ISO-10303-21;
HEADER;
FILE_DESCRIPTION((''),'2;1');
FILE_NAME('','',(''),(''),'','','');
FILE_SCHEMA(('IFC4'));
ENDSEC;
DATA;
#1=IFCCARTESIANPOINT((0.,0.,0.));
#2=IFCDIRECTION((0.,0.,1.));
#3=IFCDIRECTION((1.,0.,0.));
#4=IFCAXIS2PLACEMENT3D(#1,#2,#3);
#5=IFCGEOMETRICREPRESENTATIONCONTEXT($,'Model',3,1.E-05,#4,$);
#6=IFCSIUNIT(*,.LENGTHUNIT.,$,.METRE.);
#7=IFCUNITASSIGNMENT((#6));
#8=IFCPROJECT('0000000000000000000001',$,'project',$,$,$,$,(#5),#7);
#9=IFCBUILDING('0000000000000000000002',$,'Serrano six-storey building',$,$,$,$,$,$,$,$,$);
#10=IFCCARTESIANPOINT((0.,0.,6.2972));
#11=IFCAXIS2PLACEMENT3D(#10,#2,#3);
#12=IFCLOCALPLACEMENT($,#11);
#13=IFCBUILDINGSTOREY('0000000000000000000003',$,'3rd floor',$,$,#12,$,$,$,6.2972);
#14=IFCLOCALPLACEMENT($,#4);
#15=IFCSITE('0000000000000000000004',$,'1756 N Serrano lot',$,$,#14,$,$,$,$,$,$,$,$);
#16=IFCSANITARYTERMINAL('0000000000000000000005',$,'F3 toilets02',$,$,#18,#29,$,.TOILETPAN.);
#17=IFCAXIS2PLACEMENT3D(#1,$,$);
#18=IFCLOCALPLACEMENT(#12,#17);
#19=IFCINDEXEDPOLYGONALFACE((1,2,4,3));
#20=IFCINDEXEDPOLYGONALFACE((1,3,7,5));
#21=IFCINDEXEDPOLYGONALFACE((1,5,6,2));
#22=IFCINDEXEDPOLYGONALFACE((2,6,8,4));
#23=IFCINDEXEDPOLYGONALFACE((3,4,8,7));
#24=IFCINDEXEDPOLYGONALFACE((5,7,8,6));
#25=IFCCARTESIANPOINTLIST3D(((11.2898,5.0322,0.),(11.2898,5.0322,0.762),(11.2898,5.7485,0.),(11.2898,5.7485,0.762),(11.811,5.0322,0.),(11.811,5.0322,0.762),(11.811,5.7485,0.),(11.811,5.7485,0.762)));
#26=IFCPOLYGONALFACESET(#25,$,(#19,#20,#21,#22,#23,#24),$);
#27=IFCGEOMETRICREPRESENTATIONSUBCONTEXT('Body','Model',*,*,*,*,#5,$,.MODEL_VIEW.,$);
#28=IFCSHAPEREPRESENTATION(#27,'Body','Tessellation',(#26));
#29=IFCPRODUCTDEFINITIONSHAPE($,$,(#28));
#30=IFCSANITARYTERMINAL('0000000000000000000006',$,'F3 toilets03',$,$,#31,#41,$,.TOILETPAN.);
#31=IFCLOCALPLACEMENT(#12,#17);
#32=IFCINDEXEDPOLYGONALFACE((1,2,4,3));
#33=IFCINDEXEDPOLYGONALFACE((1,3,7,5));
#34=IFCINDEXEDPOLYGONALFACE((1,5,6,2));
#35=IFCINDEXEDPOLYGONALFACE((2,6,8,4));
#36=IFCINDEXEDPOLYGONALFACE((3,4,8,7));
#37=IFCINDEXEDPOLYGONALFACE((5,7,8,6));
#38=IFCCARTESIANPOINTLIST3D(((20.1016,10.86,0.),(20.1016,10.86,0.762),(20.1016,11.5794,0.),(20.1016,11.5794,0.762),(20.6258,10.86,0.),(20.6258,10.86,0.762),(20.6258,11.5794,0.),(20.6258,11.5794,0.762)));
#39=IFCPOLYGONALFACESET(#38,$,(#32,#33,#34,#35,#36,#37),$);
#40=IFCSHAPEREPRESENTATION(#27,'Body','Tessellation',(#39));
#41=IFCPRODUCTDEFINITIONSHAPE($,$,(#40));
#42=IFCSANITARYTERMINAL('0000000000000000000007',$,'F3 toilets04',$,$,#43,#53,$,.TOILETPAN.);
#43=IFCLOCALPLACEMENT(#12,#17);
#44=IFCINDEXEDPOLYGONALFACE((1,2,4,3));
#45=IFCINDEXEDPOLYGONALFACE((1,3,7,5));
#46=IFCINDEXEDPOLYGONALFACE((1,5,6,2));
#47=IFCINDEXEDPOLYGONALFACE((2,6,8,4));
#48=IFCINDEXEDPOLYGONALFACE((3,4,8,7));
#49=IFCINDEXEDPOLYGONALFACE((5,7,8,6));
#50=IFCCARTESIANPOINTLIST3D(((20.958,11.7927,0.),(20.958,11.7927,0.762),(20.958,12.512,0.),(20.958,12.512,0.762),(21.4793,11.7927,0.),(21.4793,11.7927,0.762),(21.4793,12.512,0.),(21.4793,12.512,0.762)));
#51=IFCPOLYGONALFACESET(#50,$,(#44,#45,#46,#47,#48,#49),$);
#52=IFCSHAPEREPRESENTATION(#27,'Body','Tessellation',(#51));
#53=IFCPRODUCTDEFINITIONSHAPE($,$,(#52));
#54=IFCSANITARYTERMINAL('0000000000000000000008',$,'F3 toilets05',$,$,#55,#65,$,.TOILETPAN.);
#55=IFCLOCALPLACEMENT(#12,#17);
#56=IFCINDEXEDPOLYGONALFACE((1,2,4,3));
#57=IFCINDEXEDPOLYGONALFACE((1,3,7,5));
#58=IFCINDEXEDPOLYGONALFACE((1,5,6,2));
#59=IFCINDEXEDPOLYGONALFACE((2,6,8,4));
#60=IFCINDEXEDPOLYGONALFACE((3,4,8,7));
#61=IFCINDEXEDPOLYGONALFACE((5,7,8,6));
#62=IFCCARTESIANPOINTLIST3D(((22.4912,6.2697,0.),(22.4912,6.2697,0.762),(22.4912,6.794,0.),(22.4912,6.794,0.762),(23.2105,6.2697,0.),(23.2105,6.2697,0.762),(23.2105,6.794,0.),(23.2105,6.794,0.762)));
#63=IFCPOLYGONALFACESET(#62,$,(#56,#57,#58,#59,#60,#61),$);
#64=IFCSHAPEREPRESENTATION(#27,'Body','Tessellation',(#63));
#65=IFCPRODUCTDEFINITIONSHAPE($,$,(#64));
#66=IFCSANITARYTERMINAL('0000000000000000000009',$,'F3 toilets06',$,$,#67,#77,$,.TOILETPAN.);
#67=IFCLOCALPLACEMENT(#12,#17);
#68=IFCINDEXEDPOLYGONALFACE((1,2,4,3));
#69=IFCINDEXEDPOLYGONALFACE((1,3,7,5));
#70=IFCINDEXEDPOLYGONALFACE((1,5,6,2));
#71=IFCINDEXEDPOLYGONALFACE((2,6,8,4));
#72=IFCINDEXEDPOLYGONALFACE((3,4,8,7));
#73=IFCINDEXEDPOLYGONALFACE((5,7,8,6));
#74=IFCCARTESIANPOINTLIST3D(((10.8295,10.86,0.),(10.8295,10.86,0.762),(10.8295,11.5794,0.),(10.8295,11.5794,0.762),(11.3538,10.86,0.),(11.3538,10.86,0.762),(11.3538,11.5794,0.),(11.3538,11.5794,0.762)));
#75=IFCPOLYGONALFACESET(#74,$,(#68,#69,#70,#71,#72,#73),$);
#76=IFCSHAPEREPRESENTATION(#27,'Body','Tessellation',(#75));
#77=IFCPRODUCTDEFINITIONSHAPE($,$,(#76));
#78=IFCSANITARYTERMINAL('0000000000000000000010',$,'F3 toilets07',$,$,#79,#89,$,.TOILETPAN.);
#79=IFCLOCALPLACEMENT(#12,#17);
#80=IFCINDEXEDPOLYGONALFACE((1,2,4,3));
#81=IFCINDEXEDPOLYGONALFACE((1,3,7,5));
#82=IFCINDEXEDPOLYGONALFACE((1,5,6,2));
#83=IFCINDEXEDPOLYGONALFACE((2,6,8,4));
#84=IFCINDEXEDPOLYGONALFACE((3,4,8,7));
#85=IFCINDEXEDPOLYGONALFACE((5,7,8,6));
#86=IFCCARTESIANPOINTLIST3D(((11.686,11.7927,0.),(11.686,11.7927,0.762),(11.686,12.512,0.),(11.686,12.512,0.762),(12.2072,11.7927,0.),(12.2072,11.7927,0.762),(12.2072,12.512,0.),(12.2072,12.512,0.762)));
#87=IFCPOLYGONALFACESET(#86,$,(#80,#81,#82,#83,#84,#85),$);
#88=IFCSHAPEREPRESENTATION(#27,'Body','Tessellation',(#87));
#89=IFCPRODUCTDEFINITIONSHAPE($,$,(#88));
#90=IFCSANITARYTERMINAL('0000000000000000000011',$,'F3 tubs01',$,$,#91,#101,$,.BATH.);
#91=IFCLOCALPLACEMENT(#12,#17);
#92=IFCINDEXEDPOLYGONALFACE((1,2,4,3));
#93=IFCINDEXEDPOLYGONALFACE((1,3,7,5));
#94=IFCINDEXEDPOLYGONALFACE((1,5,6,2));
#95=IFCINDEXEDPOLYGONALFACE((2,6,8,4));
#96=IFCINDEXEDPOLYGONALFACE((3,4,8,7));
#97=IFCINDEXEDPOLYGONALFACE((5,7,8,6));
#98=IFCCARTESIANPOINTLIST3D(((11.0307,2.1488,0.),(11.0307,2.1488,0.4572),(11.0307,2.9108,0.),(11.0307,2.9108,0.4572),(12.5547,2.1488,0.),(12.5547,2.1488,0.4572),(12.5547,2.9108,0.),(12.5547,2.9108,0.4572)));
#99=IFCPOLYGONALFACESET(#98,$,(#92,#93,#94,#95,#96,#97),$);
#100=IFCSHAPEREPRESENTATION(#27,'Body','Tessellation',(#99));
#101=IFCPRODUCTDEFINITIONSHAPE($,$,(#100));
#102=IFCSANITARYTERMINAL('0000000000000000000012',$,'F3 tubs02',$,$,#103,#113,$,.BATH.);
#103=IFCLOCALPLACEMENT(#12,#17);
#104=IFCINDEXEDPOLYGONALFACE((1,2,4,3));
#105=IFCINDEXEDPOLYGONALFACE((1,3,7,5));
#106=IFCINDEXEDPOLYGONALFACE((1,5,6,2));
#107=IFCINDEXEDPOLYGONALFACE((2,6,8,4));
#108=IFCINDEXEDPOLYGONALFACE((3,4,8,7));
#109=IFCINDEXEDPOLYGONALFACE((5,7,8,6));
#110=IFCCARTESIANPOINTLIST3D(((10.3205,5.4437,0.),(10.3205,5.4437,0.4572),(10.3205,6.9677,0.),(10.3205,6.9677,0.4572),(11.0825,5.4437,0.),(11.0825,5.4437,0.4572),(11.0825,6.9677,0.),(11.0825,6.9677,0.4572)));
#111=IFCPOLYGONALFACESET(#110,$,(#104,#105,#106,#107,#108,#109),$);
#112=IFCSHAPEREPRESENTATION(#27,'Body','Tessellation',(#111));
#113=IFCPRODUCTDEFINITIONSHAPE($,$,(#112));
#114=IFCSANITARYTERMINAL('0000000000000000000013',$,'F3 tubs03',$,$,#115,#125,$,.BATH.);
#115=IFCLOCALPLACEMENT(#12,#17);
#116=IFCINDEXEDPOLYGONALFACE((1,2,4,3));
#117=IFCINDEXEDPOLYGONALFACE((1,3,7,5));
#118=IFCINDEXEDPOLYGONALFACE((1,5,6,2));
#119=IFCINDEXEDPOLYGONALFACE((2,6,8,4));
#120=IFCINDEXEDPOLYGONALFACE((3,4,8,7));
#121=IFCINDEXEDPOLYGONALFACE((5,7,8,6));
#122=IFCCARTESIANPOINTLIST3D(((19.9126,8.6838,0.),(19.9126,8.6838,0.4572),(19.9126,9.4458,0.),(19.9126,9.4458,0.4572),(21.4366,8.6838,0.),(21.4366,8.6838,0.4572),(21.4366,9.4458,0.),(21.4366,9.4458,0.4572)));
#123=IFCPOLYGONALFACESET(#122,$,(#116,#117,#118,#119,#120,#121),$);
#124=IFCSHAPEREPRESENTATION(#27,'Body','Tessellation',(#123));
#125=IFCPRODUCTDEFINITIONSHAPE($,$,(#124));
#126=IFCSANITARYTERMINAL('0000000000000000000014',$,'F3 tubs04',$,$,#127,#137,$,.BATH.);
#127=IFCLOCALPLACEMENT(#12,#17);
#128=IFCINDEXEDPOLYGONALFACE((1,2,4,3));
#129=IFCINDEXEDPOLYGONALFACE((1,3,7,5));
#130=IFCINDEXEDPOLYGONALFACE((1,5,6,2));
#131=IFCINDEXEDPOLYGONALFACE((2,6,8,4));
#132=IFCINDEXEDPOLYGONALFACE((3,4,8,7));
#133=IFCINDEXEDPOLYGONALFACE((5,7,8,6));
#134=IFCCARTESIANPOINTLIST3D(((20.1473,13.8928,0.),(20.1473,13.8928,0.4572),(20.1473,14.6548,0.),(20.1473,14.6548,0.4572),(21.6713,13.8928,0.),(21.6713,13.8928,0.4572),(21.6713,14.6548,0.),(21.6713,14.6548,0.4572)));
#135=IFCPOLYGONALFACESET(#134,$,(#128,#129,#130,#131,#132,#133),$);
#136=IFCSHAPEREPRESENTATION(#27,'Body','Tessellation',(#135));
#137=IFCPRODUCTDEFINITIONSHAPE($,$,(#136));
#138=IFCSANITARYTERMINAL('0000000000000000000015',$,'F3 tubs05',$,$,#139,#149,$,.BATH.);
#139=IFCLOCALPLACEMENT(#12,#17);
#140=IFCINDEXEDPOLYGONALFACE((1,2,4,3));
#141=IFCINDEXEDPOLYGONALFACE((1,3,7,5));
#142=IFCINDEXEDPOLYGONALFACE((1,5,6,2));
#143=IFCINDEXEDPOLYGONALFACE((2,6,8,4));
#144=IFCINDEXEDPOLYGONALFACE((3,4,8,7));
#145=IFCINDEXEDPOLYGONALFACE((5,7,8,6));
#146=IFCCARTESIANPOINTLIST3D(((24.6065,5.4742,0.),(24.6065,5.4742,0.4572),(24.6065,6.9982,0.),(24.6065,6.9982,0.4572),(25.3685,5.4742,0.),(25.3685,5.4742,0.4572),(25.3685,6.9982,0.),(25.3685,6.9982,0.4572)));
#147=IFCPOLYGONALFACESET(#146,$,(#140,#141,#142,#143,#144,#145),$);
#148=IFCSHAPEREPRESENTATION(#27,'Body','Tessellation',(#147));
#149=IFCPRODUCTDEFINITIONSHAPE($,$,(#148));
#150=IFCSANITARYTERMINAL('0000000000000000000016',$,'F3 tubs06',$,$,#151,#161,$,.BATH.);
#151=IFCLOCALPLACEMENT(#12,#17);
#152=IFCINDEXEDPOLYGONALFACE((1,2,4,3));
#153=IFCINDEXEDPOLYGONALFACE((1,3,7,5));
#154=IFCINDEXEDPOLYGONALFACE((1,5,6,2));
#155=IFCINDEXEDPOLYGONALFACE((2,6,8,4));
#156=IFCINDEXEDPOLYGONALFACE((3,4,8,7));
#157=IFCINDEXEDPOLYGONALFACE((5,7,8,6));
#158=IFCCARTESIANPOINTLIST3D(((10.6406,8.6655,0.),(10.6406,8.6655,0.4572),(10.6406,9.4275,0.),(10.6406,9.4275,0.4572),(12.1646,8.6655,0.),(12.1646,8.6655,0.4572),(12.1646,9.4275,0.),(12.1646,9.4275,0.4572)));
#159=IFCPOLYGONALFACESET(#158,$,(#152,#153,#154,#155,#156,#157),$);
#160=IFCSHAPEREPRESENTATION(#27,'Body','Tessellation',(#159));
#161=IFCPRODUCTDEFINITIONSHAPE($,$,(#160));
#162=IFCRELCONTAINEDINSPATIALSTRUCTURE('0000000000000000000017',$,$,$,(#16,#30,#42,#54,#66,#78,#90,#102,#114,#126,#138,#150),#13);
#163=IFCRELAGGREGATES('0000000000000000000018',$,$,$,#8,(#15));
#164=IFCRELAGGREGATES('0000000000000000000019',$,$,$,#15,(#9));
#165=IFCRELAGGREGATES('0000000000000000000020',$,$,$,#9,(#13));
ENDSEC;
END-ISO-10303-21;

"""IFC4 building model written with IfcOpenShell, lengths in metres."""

from ifc_helpers import new_model, si_unit, frame, origin_with_axes, place, context, subcontext, project, spatial, polyline, outline, extrude, element, save


model = new_model("IFC4")

# Units and contexts
model_context = context("Model", 3, precision=1e-05, world=origin_with_axes())
body_context = subcontext(model_context, "Body", "Model", "MODEL_VIEW")
ifc_project = project(units=[si_unit("LENGTHUNIT", "METRE")], contexts=[model_context])

# Site, building, storey
site_placement = place(None, origin_with_axes())
site = spatial("IfcSite", under=ifc_project, at=site_placement, Name="1756 N Serrano lot")
building = spatial("IfcBuilding", under=site, Name="Serrano six-storey building")
storey_placement = place(None, frame((0.0, 0.0, 6.2972), z_axis=(0.0, 0.0, 1.0), x_axis=(1.0, 0.0, 0.0)))
storey = spatial("IfcBuildingStorey", under=building, at=storey_placement, Name="3rd floor", Elevation=6.2972)

# Sanitary terminals
sanitary_terminal_1_placement = place(storey_placement, frame((0.0, 0.0, -6.2972), z_axis=(0.0, 0.0, 1.0), x_axis=(1.0, 0.0, 0.0)))
element("IfcSanitaryTerminal", 1, at=sanitary_terminal_1_placement, inside=storey, Name="F3 toilets02", PredefinedType="TOILETPAN", context=body_context, shape_type="SweptSolid", body=[
    extrude(outline(polyline([(11.811, 5.0322), (11.811, 5.7485), (11.2898, 5.7485), (11.2898, 5.0322), (11.811, 5.0322)])), frame((0.0, 0.0, 6.2972)), (0.0, 0.0, 1.0), 0.762),
])
sanitary_terminal_2_placement = place(storey_placement, frame((0.0, 0.0, -6.2972), z_axis=(0.0, 0.0, 1.0), x_axis=(1.0, 0.0, 0.0)))
element("IfcSanitaryTerminal", 2, at=sanitary_terminal_2_placement, inside=storey, Name="F3 toilets03", PredefinedType="TOILETPAN", context=body_context, shape_type="SweptSolid", body=[
    extrude(outline(polyline([(20.6258, 10.86), (20.6258, 11.5794), (20.1016, 11.5794), (20.1016, 10.86), (20.6258, 10.86)])), frame((0.0, 0.0, 6.2972)), (0.0, 0.0, 1.0), 0.762),
])
sanitary_terminal_3_placement = place(storey_placement, frame((0.0, 0.0, -6.2972), z_axis=(0.0, 0.0, 1.0), x_axis=(1.0, 0.0, 0.0)))
element("IfcSanitaryTerminal", 3, at=sanitary_terminal_3_placement, inside=storey, Name="F3 toilets04", PredefinedType="TOILETPAN", context=body_context, shape_type="SweptSolid", body=[
    extrude(outline(polyline([(21.4793, 11.7927), (21.4793, 12.512), (20.958, 12.512), (20.958, 11.7927), (21.4793, 11.7927)])), frame((0.0, 0.0, 6.2972)), (0.0, 0.0, 1.0), 0.762),
])
sanitary_terminal_4_placement = place(storey_placement, frame((0.0, 0.0, -6.2972), z_axis=(0.0, 0.0, 1.0), x_axis=(1.0, 0.0, 0.0)))
element("IfcSanitaryTerminal", 4, at=sanitary_terminal_4_placement, inside=storey, Name="F3 toilets05", PredefinedType="TOILETPAN", context=body_context, shape_type="SweptSolid", body=[
    extrude(outline(polyline([(23.2105, 6.2697), (23.2105, 6.794), (22.4912, 6.794), (22.4912, 6.2697), (23.2105, 6.2697)])), frame((0.0, 0.0, 6.2972)), (0.0, 0.0, 1.0), 0.762),
])
sanitary_terminal_5_placement = place(storey_placement, frame((0.0, 0.0, -6.2972), z_axis=(0.0, 0.0, 1.0), x_axis=(1.0, 0.0, 0.0)))
element("IfcSanitaryTerminal", 5, at=sanitary_terminal_5_placement, inside=storey, Name="F3 toilets06", PredefinedType="TOILETPAN", context=body_context, shape_type="SweptSolid", body=[
    extrude(outline(polyline([(11.3538, 10.86), (11.3538, 11.5794), (10.8295, 11.5794), (10.8295, 10.86), (11.3538, 10.86)])), frame((0.0, 0.0, 6.2972)), (0.0, 0.0, 1.0), 0.762),
])
sanitary_terminal_6_placement = place(storey_placement, frame((0.0, 0.0, -6.2972), z_axis=(0.0, 0.0, 1.0), x_axis=(1.0, 0.0, 0.0)))
element("IfcSanitaryTerminal", 6, at=sanitary_terminal_6_placement, inside=storey, Name="F3 toilets07", PredefinedType="TOILETPAN", context=body_context, shape_type="SweptSolid", body=[
    extrude(outline(polyline([(12.2072, 11.7927), (12.2072, 12.512), (11.686, 12.512), (11.686, 11.7927), (12.2072, 11.7927)])), frame((0.0, 0.0, 6.2972)), (0.0, 0.0, 1.0), 0.762),
])
sanitary_terminal_7_placement = place(storey_placement, frame((0.0, 0.0, -6.2972), z_axis=(0.0, 0.0, 1.0), x_axis=(1.0, 0.0, 0.0)))
element("IfcSanitaryTerminal", 7, at=sanitary_terminal_7_placement, inside=storey, Name="F3 tubs01", PredefinedType="BATH", context=body_context, shape_type="SweptSolid", body=[
    extrude(outline(polyline([(12.5547, 2.1488), (12.5547, 2.9108), (11.0307, 2.9108), (11.0307, 2.1488), (12.5547, 2.1488)])), frame((0.0, 0.0, 6.2972)), (0.0, 0.0, 1.0), 0.4572),
])
sanitary_terminal_8_placement = place(storey_placement, frame((0.0, 0.0, -6.2972), z_axis=(0.0, 0.0, 1.0), x_axis=(1.0, 0.0, 0.0)))
element("IfcSanitaryTerminal", 8, at=sanitary_terminal_8_placement, inside=storey, Name="F3 tubs02", PredefinedType="BATH", context=body_context, shape_type="SweptSolid", body=[
    extrude(outline(polyline([(11.0825, 5.4437), (11.0825, 6.9677), (10.3205, 6.9677), (10.3205, 5.4437), (11.0825, 5.4437)])), frame((0.0, 0.0, 6.2972)), (0.0, 0.0, 1.0), 0.4572),
])
sanitary_terminal_9_placement = place(storey_placement, frame((0.0, 0.0, -6.2972), z_axis=(0.0, 0.0, 1.0), x_axis=(1.0, 0.0, 0.0)))
element("IfcSanitaryTerminal", 9, at=sanitary_terminal_9_placement, inside=storey, Name="F3 tubs03", PredefinedType="BATH", context=body_context, shape_type="SweptSolid", body=[
    extrude(outline(polyline([(21.4366, 8.6838), (21.4366, 9.4458), (19.9126, 9.4458), (19.9126, 8.6838), (21.4366, 8.6838)])), frame((0.0, 0.0, 6.2972)), (0.0, 0.0, 1.0), 0.4572),
])
sanitary_terminal_10_placement = place(storey_placement, frame((0.0, 0.0, -6.2972), z_axis=(0.0, 0.0, 1.0), x_axis=(1.0, 0.0, 0.0)))
element("IfcSanitaryTerminal", 10, at=sanitary_terminal_10_placement, inside=storey, Name="F3 tubs04", PredefinedType="BATH", context=body_context, shape_type="SweptSolid", body=[
    extrude(outline(polyline([(21.6713, 13.8928), (21.6713, 14.6548), (20.1473, 14.6548), (20.1473, 13.8928), (21.6713, 13.8928)])), frame((0.0, 0.0, 6.2972)), (0.0, 0.0, 1.0), 0.4572),
])
sanitary_terminal_11_placement = place(storey_placement, frame((0.0, 0.0, -6.2972), z_axis=(0.0, 0.0, 1.0), x_axis=(1.0, 0.0, 0.0)))
element("IfcSanitaryTerminal", 11, at=sanitary_terminal_11_placement, inside=storey, Name="F3 tubs05", PredefinedType="BATH", context=body_context, shape_type="SweptSolid", body=[
    extrude(outline(polyline([(25.3685, 5.4742), (25.3685, 6.9982), (24.6065, 6.9982), (24.6065, 5.4742), (25.3685, 5.4742)])), frame((0.0, 0.0, 6.2972)), (0.0, 0.0, 1.0), 0.4572),
])
sanitary_terminal_12_placement = place(storey_placement, frame((0.0, 0.0, -6.2972), z_axis=(0.0, 0.0, 1.0), x_axis=(1.0, 0.0, 0.0)))
element("IfcSanitaryTerminal", 12, at=sanitary_terminal_12_placement, inside=storey, Name="F3 tubs06", PredefinedType="BATH", context=body_context, shape_type="SweptSolid", body=[
    extrude(outline(polyline([(12.1646, 8.6655), (12.1646, 9.4275), (10.6406, 9.4275), (10.6406, 8.6655), (12.1646, 8.6655)])), frame((0.0, 0.0, 6.2972)), (0.0, 0.0, 1.0), 0.4572),
])

save(model, "model.ifc")
